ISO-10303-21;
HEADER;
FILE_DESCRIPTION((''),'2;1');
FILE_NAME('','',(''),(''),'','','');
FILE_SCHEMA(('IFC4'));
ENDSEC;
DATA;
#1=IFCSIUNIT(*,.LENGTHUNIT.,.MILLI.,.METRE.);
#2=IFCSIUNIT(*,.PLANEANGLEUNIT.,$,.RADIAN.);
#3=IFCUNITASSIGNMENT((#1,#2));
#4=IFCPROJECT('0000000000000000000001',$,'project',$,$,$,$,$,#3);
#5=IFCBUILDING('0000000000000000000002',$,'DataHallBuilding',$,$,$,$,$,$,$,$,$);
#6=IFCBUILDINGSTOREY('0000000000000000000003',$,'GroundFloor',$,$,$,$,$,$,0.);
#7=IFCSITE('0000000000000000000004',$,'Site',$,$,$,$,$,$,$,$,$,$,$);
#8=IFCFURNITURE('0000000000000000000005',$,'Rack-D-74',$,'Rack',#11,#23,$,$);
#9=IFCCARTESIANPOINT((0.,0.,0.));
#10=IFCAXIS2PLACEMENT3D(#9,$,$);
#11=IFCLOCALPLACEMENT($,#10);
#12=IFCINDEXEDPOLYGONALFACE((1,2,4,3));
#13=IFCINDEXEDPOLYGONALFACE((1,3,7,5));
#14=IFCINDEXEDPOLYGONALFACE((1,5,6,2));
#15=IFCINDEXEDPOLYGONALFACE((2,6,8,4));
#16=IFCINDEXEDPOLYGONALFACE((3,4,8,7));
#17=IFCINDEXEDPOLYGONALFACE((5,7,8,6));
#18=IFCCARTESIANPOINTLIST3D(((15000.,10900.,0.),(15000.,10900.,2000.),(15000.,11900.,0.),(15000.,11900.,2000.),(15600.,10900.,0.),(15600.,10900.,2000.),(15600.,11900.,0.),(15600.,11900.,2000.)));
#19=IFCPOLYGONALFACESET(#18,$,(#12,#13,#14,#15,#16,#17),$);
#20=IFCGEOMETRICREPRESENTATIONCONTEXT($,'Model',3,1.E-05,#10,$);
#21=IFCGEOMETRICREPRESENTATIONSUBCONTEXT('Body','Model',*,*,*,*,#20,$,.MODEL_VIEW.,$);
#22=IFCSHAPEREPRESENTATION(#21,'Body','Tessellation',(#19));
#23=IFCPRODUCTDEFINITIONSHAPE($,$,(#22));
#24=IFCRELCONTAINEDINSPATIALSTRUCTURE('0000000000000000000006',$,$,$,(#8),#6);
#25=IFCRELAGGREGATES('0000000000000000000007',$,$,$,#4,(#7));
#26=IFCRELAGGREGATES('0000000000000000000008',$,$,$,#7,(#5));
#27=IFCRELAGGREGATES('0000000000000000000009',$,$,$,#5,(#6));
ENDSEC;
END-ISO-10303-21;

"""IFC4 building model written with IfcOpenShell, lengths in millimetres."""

from ifc_helpers import new_model, si_unit, frame, origin, place, context, subcontext, project, spatial, rectangle, extrude, element, save


model = new_model("IFC4")

# Units and contexts
model_context = context("Model", 3, precision=1e-05, world=origin())
body_context = subcontext(model_context, "Body", "Model", "MODEL_VIEW")
ifc_project = project(units=[si_unit("LENGTHUNIT", "METRE", prefix="MILLI"), si_unit("PLANEANGLEUNIT", "RADIAN")])

# Site, building, storey
site = spatial("IfcSite", under=ifc_project, Name="Site")
building = spatial("IfcBuilding", under=site, Name="DataHallBuilding")
storey = spatial("IfcBuildingStorey", under=building, Name="GroundFloor", Elevation=0.0)

# Furniture
furniture_1_placement = place(None, origin())
element("IfcFurniture", 1, at=furniture_1_placement, inside=storey, Name="Rack-D-74", ObjectType="Rack", context=body_context, shape_type="SweptSolid", body=[
    extrude(rectangle(XDim=600.0, YDim=1000.0), frame((15300.0, 11400.0, 0.0), z_axis=(0.0, 0.0, 1.0), x_axis=(1.0, 0.0, 0.0)), (0.0, 0.0, 1.0), 2000.0),
])

save(model, "model.ifc")
